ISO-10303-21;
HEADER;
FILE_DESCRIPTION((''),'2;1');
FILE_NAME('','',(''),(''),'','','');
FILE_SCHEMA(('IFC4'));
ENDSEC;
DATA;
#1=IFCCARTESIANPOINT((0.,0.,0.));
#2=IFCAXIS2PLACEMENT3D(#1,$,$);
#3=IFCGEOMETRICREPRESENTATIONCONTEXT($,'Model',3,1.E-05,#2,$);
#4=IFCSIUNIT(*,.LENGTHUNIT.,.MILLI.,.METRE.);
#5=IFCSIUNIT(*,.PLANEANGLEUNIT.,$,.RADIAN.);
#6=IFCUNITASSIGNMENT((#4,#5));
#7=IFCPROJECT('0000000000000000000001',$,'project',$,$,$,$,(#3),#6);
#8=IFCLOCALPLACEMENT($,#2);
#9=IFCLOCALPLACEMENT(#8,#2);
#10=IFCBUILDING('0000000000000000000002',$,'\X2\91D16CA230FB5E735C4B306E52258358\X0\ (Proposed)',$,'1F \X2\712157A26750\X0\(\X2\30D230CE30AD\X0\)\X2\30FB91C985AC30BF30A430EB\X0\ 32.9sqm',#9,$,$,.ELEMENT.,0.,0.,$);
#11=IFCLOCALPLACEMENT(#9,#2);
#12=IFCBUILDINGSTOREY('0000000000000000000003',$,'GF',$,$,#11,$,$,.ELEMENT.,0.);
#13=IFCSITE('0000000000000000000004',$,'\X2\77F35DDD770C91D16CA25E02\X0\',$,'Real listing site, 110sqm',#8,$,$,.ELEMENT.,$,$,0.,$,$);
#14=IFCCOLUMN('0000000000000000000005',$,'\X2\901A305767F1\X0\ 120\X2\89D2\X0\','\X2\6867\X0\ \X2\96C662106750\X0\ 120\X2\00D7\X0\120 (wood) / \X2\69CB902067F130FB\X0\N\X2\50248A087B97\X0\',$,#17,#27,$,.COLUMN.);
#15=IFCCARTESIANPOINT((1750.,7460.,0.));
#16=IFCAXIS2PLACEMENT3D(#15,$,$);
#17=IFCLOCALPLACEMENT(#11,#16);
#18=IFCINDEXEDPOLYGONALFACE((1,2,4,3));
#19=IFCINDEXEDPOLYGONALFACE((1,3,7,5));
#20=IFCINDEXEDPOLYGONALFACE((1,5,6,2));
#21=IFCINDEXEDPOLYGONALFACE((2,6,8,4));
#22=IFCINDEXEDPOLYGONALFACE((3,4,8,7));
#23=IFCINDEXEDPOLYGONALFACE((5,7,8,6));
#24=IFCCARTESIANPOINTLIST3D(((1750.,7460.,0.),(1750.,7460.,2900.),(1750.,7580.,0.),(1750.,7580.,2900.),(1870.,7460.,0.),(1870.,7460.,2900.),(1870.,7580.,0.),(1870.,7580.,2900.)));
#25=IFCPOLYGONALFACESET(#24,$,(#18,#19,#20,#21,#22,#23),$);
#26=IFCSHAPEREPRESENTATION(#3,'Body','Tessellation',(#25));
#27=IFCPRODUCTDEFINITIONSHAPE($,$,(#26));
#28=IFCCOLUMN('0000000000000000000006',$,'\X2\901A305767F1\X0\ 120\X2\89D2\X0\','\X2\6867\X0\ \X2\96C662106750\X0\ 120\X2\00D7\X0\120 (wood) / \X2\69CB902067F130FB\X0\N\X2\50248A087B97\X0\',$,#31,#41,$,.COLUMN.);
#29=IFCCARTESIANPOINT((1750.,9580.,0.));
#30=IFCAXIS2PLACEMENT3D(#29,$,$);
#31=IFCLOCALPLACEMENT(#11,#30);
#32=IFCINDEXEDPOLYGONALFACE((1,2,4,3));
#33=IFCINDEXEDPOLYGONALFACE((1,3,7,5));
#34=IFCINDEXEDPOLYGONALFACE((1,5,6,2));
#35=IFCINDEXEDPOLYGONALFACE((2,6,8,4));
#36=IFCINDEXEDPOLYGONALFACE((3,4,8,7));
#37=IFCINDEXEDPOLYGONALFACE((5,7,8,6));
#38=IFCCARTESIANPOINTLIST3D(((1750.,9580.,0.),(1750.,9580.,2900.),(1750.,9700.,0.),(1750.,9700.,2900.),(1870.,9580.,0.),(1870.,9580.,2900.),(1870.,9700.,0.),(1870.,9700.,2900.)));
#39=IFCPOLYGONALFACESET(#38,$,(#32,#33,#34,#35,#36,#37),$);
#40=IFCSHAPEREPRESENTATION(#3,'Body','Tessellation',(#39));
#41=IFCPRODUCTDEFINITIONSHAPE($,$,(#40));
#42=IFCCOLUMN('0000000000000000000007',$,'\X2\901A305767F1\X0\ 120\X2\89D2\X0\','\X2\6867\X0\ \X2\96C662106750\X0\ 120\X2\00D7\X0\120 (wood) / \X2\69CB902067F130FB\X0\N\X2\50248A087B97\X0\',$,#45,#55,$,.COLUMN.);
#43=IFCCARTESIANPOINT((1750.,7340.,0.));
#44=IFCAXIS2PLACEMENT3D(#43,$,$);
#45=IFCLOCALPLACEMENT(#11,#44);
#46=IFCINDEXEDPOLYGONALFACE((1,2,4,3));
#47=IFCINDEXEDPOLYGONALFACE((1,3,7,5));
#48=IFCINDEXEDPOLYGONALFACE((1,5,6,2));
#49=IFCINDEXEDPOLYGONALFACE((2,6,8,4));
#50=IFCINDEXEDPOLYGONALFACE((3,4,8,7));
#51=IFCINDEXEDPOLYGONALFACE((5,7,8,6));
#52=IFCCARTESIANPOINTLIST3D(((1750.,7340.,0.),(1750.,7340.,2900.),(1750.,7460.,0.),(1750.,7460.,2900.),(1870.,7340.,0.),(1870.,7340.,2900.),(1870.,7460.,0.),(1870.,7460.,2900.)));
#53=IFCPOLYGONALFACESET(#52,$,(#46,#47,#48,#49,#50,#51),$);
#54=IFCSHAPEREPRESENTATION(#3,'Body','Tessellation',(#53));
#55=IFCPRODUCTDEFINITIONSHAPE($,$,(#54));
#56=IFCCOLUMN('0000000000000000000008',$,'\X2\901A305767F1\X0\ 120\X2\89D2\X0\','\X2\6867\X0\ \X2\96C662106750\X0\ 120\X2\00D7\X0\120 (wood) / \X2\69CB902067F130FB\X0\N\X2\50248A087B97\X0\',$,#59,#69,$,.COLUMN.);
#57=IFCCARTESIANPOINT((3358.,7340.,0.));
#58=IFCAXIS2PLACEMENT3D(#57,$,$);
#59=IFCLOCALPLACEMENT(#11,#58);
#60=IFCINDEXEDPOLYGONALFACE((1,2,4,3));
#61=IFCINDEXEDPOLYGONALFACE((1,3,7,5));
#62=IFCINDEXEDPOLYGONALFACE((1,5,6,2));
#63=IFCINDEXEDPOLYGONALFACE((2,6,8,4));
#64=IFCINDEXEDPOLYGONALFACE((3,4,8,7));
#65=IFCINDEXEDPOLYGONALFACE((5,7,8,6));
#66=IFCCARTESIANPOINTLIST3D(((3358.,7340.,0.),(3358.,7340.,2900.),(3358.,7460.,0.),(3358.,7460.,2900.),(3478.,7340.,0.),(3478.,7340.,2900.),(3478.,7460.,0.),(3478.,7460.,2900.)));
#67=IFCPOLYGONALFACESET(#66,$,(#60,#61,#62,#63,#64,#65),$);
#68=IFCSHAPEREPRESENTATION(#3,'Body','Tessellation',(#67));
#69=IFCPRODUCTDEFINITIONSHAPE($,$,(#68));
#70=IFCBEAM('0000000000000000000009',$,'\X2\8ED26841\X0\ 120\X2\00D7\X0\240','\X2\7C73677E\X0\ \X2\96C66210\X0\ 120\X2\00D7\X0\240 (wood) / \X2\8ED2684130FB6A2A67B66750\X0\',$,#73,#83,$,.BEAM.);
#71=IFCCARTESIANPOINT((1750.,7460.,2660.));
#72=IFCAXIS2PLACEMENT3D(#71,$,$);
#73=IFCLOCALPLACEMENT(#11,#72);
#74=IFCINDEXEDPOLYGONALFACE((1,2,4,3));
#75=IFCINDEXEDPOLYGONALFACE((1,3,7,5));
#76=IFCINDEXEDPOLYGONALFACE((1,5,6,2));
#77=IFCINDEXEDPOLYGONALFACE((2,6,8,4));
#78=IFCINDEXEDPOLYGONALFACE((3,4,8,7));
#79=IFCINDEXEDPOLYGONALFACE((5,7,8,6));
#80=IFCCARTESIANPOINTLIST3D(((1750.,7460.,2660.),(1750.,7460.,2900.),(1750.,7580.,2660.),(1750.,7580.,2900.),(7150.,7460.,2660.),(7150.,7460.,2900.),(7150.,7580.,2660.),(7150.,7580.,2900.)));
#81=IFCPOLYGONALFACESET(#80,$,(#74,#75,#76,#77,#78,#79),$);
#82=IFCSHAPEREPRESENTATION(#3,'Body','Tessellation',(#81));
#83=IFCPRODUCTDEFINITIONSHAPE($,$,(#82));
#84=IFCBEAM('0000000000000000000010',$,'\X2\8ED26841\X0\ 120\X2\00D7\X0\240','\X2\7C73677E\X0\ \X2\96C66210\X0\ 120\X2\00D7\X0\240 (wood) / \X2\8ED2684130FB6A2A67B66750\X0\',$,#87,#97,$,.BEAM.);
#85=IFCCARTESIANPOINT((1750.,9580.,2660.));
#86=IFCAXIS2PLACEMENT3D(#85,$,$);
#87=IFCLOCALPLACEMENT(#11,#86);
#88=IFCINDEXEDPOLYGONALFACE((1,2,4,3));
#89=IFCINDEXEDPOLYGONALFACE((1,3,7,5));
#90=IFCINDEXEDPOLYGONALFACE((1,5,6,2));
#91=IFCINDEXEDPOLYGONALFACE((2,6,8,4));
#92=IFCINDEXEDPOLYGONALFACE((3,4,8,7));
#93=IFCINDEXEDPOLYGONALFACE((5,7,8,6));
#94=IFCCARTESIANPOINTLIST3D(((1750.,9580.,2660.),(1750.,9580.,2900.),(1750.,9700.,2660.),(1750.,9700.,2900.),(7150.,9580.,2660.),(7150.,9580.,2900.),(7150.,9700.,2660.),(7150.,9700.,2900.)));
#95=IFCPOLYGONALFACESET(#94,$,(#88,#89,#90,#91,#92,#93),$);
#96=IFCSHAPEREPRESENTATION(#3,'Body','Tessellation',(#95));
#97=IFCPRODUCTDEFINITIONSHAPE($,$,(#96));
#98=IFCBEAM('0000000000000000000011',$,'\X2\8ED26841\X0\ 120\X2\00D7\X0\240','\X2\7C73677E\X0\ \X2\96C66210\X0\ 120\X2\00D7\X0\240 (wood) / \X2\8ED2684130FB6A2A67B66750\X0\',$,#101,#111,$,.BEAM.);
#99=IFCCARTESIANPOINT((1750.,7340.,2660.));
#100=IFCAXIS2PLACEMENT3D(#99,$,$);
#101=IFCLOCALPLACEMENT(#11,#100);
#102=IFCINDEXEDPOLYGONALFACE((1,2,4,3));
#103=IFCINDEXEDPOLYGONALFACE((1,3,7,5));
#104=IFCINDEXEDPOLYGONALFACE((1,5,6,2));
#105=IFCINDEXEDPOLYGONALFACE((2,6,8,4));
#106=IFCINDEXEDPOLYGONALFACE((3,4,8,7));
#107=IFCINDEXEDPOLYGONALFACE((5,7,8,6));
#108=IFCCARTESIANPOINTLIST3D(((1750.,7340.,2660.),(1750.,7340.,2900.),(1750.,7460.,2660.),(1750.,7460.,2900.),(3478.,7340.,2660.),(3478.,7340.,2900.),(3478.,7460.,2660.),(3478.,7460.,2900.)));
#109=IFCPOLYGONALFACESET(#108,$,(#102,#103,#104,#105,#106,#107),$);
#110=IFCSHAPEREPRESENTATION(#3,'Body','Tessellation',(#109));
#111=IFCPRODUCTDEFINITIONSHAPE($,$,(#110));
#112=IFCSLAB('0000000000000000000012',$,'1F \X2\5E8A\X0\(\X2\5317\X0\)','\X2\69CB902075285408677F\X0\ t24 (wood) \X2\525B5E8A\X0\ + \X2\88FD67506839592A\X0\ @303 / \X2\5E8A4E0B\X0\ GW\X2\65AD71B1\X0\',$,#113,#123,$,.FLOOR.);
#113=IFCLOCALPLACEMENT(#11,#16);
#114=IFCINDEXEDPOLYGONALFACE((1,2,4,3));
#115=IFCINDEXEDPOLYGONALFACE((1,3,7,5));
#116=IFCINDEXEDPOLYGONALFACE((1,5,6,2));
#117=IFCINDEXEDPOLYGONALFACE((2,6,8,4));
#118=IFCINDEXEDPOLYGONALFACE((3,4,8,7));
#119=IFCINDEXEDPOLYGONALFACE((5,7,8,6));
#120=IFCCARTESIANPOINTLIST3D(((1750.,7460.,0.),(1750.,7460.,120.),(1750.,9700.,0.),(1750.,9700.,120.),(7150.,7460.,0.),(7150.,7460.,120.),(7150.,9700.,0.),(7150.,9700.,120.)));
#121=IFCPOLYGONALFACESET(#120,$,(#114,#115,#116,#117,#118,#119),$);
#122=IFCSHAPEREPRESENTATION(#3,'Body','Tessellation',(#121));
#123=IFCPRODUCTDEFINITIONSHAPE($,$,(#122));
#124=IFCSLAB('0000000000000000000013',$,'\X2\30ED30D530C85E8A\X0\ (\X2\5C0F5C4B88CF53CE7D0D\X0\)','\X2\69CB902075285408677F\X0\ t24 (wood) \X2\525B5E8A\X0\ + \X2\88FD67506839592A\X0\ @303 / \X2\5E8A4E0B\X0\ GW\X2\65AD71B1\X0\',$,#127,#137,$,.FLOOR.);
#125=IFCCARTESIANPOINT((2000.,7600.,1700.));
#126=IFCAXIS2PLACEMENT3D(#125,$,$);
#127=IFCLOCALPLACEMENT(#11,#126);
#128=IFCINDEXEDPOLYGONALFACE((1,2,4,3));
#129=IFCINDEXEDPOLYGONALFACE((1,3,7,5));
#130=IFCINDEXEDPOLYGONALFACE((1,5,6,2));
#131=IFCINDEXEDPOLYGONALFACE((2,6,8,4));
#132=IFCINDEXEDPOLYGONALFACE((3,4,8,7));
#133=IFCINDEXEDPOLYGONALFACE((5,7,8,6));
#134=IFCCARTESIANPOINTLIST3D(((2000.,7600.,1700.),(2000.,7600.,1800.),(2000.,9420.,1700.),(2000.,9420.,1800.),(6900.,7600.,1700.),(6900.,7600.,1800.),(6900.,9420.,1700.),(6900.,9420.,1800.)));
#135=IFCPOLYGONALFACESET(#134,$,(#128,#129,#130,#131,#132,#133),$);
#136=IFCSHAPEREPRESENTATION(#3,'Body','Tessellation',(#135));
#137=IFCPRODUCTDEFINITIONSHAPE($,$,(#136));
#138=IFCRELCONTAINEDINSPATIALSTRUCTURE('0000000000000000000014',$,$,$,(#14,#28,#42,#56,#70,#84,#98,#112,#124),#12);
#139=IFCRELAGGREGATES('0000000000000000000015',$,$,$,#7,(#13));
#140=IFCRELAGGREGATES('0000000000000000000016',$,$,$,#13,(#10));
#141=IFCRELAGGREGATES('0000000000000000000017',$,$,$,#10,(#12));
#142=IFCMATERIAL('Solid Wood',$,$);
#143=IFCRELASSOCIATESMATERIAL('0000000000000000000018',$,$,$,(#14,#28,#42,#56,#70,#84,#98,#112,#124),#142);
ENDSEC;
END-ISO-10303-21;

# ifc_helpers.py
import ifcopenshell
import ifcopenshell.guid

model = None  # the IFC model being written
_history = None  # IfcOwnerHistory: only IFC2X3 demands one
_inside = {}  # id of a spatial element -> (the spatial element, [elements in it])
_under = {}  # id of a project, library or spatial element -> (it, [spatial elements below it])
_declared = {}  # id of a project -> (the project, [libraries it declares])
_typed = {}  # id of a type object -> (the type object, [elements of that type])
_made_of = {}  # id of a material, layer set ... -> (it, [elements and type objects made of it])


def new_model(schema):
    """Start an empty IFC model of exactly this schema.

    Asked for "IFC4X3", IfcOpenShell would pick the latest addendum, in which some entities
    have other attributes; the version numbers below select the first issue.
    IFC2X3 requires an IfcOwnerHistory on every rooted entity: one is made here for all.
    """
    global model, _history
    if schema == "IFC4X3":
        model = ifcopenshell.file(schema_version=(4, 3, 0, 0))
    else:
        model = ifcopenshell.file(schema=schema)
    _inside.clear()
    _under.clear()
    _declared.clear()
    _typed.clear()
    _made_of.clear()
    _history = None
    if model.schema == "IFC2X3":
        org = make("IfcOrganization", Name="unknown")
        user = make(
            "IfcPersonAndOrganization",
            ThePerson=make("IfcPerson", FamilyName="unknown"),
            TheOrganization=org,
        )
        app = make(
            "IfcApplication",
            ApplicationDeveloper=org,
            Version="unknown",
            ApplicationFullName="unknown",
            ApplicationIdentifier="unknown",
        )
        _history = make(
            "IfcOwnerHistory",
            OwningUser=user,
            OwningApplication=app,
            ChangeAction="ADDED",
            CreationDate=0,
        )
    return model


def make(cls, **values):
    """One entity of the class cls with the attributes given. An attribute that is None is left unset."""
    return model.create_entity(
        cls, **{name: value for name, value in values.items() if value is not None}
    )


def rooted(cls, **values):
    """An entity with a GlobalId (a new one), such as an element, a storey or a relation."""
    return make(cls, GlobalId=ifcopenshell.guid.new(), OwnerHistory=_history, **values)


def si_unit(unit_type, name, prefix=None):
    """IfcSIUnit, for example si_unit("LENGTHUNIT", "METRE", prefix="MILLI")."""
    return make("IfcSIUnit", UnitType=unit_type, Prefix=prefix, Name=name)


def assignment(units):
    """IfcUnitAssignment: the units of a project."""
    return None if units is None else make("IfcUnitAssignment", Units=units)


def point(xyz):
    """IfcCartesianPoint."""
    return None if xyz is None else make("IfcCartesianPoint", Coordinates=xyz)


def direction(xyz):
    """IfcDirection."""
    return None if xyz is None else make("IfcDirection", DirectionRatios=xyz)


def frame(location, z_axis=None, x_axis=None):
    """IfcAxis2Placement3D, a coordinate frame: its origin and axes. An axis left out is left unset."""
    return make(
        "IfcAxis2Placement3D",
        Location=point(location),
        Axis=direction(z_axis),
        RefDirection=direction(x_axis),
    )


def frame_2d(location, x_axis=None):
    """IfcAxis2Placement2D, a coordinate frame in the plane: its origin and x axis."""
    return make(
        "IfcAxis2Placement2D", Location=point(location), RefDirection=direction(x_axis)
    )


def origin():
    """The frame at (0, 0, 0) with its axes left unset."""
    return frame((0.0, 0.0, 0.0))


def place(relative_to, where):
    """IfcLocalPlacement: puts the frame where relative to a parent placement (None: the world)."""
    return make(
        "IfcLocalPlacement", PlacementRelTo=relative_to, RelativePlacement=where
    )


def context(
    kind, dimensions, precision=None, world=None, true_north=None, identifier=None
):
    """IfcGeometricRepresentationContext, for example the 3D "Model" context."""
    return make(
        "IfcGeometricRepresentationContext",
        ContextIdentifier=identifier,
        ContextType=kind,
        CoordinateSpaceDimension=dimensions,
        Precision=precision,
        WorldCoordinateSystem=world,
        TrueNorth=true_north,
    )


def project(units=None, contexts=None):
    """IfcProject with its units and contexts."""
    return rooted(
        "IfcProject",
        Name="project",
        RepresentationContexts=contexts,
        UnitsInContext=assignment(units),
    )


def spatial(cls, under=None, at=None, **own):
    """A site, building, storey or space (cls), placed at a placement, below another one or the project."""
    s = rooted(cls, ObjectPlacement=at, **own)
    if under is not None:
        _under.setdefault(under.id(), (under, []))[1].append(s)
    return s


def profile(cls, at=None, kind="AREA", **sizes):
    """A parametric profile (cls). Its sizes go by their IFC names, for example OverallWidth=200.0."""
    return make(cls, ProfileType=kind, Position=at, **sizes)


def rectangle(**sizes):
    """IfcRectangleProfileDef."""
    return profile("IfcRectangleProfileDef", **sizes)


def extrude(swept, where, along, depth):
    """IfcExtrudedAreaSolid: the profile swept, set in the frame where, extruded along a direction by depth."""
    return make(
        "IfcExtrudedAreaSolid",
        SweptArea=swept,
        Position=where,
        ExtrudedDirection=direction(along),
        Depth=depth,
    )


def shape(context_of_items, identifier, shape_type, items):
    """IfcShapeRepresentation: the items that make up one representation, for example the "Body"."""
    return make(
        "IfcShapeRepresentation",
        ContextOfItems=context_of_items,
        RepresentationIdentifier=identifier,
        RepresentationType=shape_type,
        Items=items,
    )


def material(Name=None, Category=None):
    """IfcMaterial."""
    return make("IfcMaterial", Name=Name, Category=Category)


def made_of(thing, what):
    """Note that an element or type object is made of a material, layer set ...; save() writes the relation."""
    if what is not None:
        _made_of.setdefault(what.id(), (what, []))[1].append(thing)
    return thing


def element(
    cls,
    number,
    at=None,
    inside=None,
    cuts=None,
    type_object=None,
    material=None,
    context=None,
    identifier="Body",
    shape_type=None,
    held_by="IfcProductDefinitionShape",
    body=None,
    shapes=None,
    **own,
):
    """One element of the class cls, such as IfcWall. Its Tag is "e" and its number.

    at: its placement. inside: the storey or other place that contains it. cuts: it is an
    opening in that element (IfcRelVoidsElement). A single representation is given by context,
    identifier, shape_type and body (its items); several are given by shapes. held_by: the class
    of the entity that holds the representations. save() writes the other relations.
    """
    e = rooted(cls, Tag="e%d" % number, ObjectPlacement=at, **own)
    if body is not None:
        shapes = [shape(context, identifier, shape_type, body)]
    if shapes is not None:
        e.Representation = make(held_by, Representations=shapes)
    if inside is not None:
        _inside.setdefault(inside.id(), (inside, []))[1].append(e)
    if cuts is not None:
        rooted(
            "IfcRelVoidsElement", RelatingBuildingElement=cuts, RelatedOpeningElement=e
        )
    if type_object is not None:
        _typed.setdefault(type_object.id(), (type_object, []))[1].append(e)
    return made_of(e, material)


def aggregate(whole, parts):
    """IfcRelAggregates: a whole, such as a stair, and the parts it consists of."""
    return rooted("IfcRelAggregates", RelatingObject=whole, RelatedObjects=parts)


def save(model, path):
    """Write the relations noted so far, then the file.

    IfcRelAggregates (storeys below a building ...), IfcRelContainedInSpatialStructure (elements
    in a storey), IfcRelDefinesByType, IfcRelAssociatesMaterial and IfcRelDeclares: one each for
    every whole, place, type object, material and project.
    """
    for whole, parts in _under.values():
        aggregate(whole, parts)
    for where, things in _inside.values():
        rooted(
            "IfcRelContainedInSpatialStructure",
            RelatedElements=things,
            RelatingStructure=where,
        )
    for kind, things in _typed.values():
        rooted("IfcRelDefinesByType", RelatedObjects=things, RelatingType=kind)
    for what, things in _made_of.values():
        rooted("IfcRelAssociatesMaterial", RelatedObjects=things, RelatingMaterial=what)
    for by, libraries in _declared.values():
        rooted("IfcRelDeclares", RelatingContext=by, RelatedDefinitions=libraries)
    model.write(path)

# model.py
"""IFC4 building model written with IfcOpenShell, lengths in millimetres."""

from ifc_helpers import new_model, si_unit, frame, frame_2d, origin, place, context, project, spatial, rectangle, extrude, material, element, save


model = new_model("IFC4")

# Units and contexts
model_context = context("Model", 3, precision=1e-05, world=origin())
ifc_project = project(units=[si_unit("LENGTHUNIT", "METRE", prefix="MILLI"), si_unit("PLANEANGLEUNIT", "RADIAN")], contexts=[model_context])

# Site, building, storey
site_placement = place(None, origin())
site = spatial("IfcSite", under=ifc_project, at=site_placement, Name="石川県金沢市", ObjectType="Real listing site, 110sqm", CompositionType="ELEMENT", RefElevation=0.0)
building_placement = place(site_placement, origin())
building = spatial("IfcBuilding", under=site, at=building_placement, Name="金沢・平屋の別荘 (Proposed)", ObjectType="1F 無垢材(ヒノキ)・釉薬タイル 32.9sqm", CompositionType="ELEMENT", ElevationOfRefHeight=0.0, ElevationOfTerrain=0.0)
storey_placement = place(building_placement, origin())
storey = spatial("IfcBuildingStorey", under=building, at=storey_placement, Name="GF", CompositionType="ELEMENT", Elevation=0.0)

# Columns
ifc_material_1 = material(Name="Solid Wood")
column_1_placement = place(storey_placement, frame((1750.0, 7460.0, 0.0)))
element("IfcColumn", 1, at=column_1_placement, inside=storey, material=ifc_material_1, Name="通し柱 120角", Description="桧 集成材 120×120 (wood) / 構造柱・N値計算", PredefinedType="COLUMN", context=model_context, shape_type="SweptSolid", body=[
    extrude(rectangle(XDim=120.0, YDim=120.0, at=frame_2d((60.0, 60.0))), frame((1750.0, 7460.0, 0.0)), (0.0, 0.0, 1.0), 2900.0),
])
column_2_placement = place(storey_placement, frame((1750.0, 9580.0, 0.0)))
element("IfcColumn", 2, at=column_2_placement, inside=storey, material=ifc_material_1, Name="通し柱 120角", Description="桧 集成材 120×120 (wood) / 構造柱・N値計算", PredefinedType="COLUMN", context=model_context, shape_type="SweptSolid", body=[
    extrude(rectangle(XDim=120.0, YDim=120.0, at=frame_2d((60.0, 60.0))), frame((1750.0, 9580.0, 0.0)), (0.0, 0.0, 1.0), 2900.0),
])
column_3_placement = place(storey_placement, frame((1750.0, 7340.0, 0.0)))
element("IfcColumn", 3, at=column_3_placement, inside=storey, material=ifc_material_1, Name="通し柱 120角", Description="桧 集成材 120×120 (wood) / 構造柱・N値計算", PredefinedType="COLUMN", context=model_context, shape_type="SweptSolid", body=[
    extrude(rectangle(XDim=120.0, YDim=120.0, at=frame_2d((60.0, 60.0))), frame((1750.0, 7340.0, 0.0)), (0.0, 0.0, 1.0), 2900.0),
])
column_4_placement = place(storey_placement, frame((3358.0, 7340.0, 0.0)))
element("IfcColumn", 4, at=column_4_placement, inside=storey, material=ifc_material_1, Name="通し柱 120角", Description="桧 集成材 120×120 (wood) / 構造柱・N値計算", PredefinedType="COLUMN", context=model_context, shape_type="SweptSolid", body=[
    extrude(rectangle(XDim=120.0, YDim=120.0, at=frame_2d((60.0, 60.0))), frame((3358.0, 7340.0, 0.0)), (0.0, 0.0, 1.0), 2900.0),
])

# Beams
beam_1_placement = place(storey_placement, frame((1750.0, 7460.0, 2660.0)))
element("IfcBeam", 5, at=beam_1_placement, inside=storey, material=ifc_material_1, Name="軒桁 120×240", Description="米松 集成 120×240 (wood) / 軒桁・横架材", PredefinedType="BEAM", context=model_context, shape_type="SweptSolid", body=[
    extrude(rectangle(XDim=5400.0, YDim=120.0, at=frame_2d((2700.0, 60.0))), frame((1750.0, 7460.0, 2660.0)), (0.0, 0.0, 1.0), 240.0),
])
beam_2_placement = place(storey_placement, frame((1750.0, 9580.0, 2660.0)))
element("IfcBeam", 6, at=beam_2_placement, inside=storey, material=ifc_material_1, Name="軒桁 120×240", Description="米松 集成 120×240 (wood) / 軒桁・横架材", PredefinedType="BEAM", context=model_context, shape_type="SweptSolid", body=[
    extrude(rectangle(XDim=5400.0, YDim=120.0, at=frame_2d((2700.0, 60.0))), frame((1750.0, 9580.0, 2660.0)), (0.0, 0.0, 1.0), 240.0),
])
beam_3_placement = place(storey_placement, frame((1750.0, 7340.0, 2660.0)))
element("IfcBeam", 7, at=beam_3_placement, inside=storey, material=ifc_material_1, Name="軒桁 120×240", Description="米松 集成 120×240 (wood) / 軒桁・横架材", PredefinedType="BEAM", context=model_context, shape_type="SweptSolid", body=[
    extrude(rectangle(XDim=1728.0, YDim=120.0, at=frame_2d((864.0, 60.0))), frame((1750.0, 7340.0, 2660.0)), (0.0, 0.0, 1.0), 240.0),
])

# Slabs
slab_1_placement = place(storey_placement, frame((1750.0, 7460.0, 0.0)))
element("IfcSlab", 8, at=slab_1_placement, inside=storey, material=ifc_material_1, Name="1F 床(北)", Description="構造用合板 t24 (wood) 剛床 + 製材根太 @303 / 床下 GW断熱", PredefinedType="FLOOR", context=model_context, shape_type="SweptSolid", body=[
    extrude(rectangle(XDim=5400.0, YDim=2240.0, at=frame_2d((2700.0, 1120.0))), frame((1750.0, 7460.0, 0.0)), (0.0, 0.0, 1.0), 120.0),
])
slab_2_placement = place(storey_placement, frame((2000.0, 7600.0, 1700.0)))
element("IfcSlab", 9, at=slab_2_placement, inside=storey, material=ifc_material_1, Name="ロフト床 (小屋裏収納)", Description="構造用合板 t24 (wood) 剛床 + 製材根太 @303 / 床下 GW断熱", PredefinedType="FLOOR", context=model_context, shape_type="SweptSolid", body=[
    extrude(rectangle(XDim=4900.0, YDim=1820.0, at=frame_2d((2450.0, 910.0))), frame((2000.0, 7600.0, 1700.0)), (0.0, 0.0, 1.0), 100.0),
])

save(model, "model.ifc")
